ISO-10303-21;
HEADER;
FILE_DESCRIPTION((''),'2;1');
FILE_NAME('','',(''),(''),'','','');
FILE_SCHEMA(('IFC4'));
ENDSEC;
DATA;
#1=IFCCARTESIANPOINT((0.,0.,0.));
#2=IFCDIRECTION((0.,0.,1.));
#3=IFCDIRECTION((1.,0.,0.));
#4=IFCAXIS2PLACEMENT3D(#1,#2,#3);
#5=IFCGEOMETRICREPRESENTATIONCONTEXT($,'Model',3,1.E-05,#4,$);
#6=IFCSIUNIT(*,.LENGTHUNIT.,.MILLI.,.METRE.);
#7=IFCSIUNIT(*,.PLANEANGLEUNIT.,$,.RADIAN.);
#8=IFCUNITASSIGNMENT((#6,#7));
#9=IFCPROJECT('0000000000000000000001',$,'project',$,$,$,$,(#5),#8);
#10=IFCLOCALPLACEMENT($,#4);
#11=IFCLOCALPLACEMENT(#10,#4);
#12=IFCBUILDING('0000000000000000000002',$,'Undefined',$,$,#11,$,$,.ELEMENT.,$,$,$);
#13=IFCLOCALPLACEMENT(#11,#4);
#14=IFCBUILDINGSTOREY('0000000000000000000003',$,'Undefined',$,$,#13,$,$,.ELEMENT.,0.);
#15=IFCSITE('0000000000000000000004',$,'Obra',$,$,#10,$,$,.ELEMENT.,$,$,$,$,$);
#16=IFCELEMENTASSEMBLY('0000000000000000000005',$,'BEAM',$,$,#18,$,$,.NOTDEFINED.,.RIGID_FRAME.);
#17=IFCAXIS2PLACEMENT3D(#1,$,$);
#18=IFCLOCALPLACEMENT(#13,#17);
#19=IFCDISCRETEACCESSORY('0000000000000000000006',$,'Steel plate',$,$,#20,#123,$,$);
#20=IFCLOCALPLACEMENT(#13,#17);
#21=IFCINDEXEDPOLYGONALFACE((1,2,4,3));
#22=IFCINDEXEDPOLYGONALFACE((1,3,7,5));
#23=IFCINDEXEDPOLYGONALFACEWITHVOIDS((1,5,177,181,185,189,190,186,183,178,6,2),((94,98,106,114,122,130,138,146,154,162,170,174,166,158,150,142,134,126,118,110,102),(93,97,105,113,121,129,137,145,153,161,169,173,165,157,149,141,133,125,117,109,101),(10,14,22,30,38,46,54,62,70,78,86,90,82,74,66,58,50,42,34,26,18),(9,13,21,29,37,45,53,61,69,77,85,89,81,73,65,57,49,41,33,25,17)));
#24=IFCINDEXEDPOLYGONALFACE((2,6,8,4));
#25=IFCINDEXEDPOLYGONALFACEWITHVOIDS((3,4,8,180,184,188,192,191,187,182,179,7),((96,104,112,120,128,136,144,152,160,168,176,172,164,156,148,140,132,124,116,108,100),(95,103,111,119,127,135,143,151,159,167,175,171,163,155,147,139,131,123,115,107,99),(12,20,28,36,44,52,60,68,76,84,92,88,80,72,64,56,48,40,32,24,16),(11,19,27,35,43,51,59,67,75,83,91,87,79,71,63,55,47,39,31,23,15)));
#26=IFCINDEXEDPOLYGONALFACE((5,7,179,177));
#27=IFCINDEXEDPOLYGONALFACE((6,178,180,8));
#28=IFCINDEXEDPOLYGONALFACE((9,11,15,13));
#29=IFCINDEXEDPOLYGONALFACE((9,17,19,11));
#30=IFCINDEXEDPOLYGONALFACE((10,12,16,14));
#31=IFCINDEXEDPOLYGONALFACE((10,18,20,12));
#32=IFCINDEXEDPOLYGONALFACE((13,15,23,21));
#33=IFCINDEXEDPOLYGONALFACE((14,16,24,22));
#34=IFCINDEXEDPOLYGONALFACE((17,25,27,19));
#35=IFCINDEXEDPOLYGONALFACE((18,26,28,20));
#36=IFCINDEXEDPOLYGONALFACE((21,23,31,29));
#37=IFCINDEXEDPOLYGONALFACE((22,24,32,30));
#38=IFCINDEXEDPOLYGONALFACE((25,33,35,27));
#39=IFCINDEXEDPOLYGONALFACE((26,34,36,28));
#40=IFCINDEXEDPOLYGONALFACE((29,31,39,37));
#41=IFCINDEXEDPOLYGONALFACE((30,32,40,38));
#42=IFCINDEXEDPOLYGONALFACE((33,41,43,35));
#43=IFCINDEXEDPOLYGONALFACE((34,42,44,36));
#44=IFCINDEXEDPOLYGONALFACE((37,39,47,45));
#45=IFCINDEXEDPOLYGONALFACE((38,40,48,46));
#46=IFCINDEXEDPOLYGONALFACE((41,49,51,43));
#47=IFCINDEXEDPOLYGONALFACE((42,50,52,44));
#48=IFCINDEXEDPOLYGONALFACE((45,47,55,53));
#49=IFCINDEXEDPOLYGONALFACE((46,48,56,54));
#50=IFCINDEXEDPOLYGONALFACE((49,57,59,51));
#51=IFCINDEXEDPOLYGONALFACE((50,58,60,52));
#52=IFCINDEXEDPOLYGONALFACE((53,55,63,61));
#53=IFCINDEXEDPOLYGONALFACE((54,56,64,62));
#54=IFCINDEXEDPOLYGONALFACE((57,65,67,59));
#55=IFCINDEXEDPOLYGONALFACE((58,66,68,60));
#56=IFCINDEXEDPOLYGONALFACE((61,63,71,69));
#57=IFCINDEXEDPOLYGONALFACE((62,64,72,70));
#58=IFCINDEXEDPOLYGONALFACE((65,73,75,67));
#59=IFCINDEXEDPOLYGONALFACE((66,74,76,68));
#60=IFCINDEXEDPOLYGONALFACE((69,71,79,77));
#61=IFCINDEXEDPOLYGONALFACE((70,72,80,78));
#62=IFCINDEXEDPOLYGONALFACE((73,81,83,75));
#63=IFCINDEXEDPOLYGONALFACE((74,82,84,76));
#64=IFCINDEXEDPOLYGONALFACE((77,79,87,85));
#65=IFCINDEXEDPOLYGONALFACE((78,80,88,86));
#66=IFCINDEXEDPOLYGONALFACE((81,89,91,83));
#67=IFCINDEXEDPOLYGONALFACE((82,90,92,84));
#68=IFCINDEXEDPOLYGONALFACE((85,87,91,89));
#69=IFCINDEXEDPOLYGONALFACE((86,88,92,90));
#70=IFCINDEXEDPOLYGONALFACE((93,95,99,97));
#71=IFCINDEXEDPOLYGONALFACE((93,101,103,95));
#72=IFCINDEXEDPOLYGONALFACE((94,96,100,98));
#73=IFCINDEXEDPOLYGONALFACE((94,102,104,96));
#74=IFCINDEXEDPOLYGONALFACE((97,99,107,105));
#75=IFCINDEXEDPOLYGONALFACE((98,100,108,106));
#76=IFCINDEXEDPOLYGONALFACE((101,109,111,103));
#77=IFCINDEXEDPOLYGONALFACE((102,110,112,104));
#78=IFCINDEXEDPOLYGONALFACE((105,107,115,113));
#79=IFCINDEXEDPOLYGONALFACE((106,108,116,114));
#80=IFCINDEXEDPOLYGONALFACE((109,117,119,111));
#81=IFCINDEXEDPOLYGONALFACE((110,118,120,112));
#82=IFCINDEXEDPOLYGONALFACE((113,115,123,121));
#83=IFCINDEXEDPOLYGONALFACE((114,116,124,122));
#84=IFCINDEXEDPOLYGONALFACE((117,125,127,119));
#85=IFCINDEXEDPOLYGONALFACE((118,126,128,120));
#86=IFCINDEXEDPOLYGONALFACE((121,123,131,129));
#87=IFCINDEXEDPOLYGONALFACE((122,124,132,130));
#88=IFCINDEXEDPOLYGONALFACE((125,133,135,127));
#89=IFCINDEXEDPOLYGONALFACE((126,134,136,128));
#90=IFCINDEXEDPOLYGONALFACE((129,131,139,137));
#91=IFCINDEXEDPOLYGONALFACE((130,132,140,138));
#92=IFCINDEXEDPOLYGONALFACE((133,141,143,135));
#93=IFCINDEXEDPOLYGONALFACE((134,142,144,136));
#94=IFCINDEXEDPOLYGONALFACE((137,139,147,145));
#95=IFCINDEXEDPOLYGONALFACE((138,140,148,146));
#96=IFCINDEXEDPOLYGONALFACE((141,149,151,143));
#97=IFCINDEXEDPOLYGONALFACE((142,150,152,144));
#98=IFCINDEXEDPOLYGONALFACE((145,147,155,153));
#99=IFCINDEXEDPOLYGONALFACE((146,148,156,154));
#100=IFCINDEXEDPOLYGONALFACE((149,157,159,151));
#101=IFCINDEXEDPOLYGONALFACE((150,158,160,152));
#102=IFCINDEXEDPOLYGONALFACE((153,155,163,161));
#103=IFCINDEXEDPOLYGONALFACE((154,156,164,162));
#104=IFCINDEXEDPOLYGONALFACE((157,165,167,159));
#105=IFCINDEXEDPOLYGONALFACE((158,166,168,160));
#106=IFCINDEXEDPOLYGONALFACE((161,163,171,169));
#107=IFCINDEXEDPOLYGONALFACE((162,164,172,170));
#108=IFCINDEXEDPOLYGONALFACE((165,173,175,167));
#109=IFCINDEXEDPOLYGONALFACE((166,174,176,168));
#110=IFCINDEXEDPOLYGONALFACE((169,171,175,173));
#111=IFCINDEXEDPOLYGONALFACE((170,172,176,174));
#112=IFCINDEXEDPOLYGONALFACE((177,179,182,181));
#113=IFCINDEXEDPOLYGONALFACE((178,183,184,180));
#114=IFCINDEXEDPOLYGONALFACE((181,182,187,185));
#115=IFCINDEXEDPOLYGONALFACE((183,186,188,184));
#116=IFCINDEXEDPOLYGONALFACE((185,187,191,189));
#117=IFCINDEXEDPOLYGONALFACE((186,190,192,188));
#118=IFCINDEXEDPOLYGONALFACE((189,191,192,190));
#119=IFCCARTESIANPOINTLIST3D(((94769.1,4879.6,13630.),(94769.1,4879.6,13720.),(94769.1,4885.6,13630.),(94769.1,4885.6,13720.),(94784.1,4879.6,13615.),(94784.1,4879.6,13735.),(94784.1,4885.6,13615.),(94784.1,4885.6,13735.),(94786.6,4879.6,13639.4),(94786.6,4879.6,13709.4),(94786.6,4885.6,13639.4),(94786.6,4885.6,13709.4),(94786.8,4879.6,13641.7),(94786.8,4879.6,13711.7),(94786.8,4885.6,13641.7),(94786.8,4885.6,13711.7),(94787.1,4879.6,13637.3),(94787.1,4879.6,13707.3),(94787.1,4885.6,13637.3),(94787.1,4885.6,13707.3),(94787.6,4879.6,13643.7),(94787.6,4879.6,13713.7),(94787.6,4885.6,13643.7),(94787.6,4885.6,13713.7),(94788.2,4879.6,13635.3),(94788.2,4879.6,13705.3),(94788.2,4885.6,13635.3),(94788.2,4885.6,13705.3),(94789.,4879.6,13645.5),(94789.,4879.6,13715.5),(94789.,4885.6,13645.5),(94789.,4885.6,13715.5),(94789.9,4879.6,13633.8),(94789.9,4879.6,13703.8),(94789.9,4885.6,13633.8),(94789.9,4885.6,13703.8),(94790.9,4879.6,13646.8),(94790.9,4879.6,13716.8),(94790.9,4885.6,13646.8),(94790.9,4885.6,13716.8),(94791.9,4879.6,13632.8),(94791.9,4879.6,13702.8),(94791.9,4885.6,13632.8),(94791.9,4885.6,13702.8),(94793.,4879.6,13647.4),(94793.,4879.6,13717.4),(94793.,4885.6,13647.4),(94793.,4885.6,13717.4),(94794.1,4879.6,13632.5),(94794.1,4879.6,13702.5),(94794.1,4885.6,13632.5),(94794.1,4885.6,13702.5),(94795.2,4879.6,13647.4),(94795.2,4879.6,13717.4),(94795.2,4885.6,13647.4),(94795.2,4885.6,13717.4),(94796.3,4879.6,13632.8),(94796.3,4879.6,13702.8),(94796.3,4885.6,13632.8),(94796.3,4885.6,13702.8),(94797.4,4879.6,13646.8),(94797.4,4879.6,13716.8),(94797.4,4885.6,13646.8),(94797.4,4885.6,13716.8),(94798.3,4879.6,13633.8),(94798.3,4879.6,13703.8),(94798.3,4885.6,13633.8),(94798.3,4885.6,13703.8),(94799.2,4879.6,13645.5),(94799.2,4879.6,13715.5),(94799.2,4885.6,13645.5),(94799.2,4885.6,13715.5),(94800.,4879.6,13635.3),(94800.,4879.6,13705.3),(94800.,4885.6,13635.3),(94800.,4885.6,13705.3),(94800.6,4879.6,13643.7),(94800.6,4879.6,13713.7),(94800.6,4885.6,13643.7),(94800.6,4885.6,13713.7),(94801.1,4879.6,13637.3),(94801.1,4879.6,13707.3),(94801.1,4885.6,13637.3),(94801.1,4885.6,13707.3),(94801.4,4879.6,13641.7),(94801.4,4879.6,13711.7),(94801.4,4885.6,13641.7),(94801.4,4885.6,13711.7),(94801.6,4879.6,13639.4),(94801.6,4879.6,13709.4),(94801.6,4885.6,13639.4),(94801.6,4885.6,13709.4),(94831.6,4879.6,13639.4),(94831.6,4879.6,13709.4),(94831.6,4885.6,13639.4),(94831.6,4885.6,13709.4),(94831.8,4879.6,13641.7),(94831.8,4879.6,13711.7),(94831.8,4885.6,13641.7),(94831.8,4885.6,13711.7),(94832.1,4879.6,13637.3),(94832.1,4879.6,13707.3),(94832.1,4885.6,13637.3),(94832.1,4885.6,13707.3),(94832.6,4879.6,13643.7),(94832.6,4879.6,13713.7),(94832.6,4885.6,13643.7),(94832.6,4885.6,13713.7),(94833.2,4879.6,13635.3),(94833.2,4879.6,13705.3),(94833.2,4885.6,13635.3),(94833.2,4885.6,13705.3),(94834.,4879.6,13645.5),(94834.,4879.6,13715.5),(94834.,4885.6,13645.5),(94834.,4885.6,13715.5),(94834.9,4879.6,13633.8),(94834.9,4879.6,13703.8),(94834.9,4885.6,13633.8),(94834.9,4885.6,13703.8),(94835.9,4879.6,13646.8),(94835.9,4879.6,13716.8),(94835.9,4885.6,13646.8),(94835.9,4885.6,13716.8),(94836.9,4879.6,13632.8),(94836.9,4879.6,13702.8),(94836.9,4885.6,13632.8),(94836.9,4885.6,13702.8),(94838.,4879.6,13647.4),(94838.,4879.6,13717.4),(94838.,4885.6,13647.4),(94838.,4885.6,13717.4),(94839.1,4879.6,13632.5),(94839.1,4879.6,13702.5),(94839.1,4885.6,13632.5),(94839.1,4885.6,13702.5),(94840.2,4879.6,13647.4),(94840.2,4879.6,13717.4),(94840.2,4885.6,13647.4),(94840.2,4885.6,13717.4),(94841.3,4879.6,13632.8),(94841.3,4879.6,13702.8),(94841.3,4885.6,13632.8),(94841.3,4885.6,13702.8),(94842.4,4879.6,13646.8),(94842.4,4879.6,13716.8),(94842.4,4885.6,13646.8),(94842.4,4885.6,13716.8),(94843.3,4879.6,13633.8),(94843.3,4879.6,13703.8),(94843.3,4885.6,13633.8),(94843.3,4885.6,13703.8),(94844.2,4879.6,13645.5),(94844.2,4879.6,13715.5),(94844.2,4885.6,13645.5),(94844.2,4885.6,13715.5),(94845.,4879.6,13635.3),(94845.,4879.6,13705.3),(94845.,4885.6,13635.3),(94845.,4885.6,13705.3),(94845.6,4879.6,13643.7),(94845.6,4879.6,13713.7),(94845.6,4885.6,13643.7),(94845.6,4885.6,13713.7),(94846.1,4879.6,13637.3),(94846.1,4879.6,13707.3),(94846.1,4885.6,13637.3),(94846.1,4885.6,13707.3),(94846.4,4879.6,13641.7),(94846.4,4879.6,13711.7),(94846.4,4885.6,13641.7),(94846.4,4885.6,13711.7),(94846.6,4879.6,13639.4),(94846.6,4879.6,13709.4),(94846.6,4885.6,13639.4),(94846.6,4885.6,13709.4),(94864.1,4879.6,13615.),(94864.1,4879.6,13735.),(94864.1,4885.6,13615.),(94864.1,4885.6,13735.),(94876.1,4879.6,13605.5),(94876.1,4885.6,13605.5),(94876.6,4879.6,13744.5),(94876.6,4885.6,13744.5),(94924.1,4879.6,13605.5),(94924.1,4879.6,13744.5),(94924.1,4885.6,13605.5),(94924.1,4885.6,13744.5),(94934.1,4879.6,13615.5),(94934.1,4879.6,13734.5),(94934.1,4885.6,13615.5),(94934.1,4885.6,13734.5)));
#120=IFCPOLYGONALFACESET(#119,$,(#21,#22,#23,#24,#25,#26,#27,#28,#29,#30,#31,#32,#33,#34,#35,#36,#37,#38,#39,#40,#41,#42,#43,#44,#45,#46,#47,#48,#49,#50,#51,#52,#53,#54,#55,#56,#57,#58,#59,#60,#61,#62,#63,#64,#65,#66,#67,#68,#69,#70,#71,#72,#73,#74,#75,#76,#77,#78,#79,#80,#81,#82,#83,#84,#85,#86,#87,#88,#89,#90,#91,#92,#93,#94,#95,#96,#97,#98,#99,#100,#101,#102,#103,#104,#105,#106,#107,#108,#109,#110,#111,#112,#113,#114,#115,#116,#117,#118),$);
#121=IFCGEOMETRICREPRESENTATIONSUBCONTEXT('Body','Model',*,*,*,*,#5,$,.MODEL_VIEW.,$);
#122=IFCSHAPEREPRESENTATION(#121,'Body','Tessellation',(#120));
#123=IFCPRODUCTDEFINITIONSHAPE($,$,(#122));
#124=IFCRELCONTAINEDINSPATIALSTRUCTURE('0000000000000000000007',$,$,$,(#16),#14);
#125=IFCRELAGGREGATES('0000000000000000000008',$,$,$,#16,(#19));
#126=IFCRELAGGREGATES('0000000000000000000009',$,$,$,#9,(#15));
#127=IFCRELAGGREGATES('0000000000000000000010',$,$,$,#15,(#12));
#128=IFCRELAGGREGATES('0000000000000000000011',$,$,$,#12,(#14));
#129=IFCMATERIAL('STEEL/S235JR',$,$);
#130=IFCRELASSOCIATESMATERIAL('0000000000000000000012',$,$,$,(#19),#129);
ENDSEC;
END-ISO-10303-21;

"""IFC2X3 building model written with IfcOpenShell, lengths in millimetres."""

from ifc_helpers import new_model, si_unit, frame, origin_with_axes, origin_2d_with_axis, place, context, subcontext, project, spatial, polyline, circle, outline, extrude, source, transform, mapped, material, element, aggregate, save


model = new_model("IFC2X3")

# Units and contexts
model_context = context("Model", 3, precision=1e-05, world=origin_with_axes())
body_context = subcontext(model_context, "Body", "Model", "MODEL_VIEW")
ifc_project = project(units=[si_unit("LENGTHUNIT", "METRE", prefix="MILLI"), si_unit("PLANEANGLEUNIT", "RADIAN")], contexts=[model_context])

# Site, building, storey
site_placement = place(None, origin_with_axes())
site = spatial("IfcSite", under=ifc_project, at=site_placement, Name="Obra", CompositionType="ELEMENT")
building_placement = place(site_placement, origin_with_axes())
building = spatial("IfcBuilding", under=site, at=building_placement, Name="Undefined", CompositionType="ELEMENT")
storey_placement = place(building_placement, origin_with_axes())
storey = spatial("IfcBuildingStorey", under=building, at=storey_placement, Name="Undefined", CompositionType="ELEMENT", Elevation=0.0)

# Shared definitions
ifc_material_1 = material(Name="STEEL/S235JR")

# Element assembly
assembly_1_placement = place(storey_placement, origin_with_axes())
assembly_1 = element("IfcElementAssembly", 1, at=assembly_1_placement, inside=storey, Name="BEAM", AssemblyPlace="NOTDEFINED", PredefinedType="RIGID_FRAME")

# Discrete accessory, opening
shared_shape_1 = source(origin_with_axes(), body_context, "Body", "SweptSolid", [
    extrude(circle(Radius=7.5, at=origin_2d_with_axis()), frame((0.0, 2.4, 0.0), z_axis=(0.0, 1.0, 0.0), x_axis=(1.0, 0.0, 0.0)), (0.0, 0.0, 1.0), 6.2),
])
discrete_accessory_1_placement = place(assembly_1_placement, frame((94934.1, 4882.6, 13615.5), z_axis=(0.0, 1.0, 0.0), x_axis=(-0.707107, 0.0, -0.707107)))
discrete_accessory_1 = element("IfcDiscreteAccessory", 2, at=discrete_accessory_1_placement, material=ifc_material_1, Name="Steel plate", context=body_context, shape_type="SweptSolid", body=[
    extrude(outline(polyline([(0.0, 0.0), (14.1, 0.0), (48.1, 33.9), (49.9, 49.1), (106.4, 105.7), (106.4, 126.9), (42.8, 190.6), (21.6, 190.6), (-35.0, 134.0), (-50.6, 131.9), (-84.1, 98.3), (-84.1, 84.1), (0.0, 0.0)])), frame((0.0, 0.0, -3.0), z_axis=(0.0, 0.0, 1.0), x_axis=(1.0, 0.0, 0.0)), (0.0, 0.0, 1.0), 6.0),
])
opening_1_placement = place(assembly_1_placement, frame((94816.6, 4888.1, 13710.0), z_axis=(-1.0, 0.0, 0.0), x_axis=(0.0, 0.0, -1.0)))
element("IfcOpeningElement", 3, at=opening_1_placement, cuts=discrete_accessory_1, ObjectType="Opening", context=body_context, shape_type="MappedRepresentation", body=[
    mapped(shared_shape_1, transform((0.0, 0.0, -22.5))),
    mapped(shared_shape_1, transform((70.0, 0.0, -22.5))),
    mapped(shared_shape_1, transform((0.0, 0.0, 22.5))),
    mapped(shared_shape_1, transform((70.0, 0.0, 22.5))),
])

aggregate(assembly_1, [discrete_accessory_1])

save(model, "model.ifc")
